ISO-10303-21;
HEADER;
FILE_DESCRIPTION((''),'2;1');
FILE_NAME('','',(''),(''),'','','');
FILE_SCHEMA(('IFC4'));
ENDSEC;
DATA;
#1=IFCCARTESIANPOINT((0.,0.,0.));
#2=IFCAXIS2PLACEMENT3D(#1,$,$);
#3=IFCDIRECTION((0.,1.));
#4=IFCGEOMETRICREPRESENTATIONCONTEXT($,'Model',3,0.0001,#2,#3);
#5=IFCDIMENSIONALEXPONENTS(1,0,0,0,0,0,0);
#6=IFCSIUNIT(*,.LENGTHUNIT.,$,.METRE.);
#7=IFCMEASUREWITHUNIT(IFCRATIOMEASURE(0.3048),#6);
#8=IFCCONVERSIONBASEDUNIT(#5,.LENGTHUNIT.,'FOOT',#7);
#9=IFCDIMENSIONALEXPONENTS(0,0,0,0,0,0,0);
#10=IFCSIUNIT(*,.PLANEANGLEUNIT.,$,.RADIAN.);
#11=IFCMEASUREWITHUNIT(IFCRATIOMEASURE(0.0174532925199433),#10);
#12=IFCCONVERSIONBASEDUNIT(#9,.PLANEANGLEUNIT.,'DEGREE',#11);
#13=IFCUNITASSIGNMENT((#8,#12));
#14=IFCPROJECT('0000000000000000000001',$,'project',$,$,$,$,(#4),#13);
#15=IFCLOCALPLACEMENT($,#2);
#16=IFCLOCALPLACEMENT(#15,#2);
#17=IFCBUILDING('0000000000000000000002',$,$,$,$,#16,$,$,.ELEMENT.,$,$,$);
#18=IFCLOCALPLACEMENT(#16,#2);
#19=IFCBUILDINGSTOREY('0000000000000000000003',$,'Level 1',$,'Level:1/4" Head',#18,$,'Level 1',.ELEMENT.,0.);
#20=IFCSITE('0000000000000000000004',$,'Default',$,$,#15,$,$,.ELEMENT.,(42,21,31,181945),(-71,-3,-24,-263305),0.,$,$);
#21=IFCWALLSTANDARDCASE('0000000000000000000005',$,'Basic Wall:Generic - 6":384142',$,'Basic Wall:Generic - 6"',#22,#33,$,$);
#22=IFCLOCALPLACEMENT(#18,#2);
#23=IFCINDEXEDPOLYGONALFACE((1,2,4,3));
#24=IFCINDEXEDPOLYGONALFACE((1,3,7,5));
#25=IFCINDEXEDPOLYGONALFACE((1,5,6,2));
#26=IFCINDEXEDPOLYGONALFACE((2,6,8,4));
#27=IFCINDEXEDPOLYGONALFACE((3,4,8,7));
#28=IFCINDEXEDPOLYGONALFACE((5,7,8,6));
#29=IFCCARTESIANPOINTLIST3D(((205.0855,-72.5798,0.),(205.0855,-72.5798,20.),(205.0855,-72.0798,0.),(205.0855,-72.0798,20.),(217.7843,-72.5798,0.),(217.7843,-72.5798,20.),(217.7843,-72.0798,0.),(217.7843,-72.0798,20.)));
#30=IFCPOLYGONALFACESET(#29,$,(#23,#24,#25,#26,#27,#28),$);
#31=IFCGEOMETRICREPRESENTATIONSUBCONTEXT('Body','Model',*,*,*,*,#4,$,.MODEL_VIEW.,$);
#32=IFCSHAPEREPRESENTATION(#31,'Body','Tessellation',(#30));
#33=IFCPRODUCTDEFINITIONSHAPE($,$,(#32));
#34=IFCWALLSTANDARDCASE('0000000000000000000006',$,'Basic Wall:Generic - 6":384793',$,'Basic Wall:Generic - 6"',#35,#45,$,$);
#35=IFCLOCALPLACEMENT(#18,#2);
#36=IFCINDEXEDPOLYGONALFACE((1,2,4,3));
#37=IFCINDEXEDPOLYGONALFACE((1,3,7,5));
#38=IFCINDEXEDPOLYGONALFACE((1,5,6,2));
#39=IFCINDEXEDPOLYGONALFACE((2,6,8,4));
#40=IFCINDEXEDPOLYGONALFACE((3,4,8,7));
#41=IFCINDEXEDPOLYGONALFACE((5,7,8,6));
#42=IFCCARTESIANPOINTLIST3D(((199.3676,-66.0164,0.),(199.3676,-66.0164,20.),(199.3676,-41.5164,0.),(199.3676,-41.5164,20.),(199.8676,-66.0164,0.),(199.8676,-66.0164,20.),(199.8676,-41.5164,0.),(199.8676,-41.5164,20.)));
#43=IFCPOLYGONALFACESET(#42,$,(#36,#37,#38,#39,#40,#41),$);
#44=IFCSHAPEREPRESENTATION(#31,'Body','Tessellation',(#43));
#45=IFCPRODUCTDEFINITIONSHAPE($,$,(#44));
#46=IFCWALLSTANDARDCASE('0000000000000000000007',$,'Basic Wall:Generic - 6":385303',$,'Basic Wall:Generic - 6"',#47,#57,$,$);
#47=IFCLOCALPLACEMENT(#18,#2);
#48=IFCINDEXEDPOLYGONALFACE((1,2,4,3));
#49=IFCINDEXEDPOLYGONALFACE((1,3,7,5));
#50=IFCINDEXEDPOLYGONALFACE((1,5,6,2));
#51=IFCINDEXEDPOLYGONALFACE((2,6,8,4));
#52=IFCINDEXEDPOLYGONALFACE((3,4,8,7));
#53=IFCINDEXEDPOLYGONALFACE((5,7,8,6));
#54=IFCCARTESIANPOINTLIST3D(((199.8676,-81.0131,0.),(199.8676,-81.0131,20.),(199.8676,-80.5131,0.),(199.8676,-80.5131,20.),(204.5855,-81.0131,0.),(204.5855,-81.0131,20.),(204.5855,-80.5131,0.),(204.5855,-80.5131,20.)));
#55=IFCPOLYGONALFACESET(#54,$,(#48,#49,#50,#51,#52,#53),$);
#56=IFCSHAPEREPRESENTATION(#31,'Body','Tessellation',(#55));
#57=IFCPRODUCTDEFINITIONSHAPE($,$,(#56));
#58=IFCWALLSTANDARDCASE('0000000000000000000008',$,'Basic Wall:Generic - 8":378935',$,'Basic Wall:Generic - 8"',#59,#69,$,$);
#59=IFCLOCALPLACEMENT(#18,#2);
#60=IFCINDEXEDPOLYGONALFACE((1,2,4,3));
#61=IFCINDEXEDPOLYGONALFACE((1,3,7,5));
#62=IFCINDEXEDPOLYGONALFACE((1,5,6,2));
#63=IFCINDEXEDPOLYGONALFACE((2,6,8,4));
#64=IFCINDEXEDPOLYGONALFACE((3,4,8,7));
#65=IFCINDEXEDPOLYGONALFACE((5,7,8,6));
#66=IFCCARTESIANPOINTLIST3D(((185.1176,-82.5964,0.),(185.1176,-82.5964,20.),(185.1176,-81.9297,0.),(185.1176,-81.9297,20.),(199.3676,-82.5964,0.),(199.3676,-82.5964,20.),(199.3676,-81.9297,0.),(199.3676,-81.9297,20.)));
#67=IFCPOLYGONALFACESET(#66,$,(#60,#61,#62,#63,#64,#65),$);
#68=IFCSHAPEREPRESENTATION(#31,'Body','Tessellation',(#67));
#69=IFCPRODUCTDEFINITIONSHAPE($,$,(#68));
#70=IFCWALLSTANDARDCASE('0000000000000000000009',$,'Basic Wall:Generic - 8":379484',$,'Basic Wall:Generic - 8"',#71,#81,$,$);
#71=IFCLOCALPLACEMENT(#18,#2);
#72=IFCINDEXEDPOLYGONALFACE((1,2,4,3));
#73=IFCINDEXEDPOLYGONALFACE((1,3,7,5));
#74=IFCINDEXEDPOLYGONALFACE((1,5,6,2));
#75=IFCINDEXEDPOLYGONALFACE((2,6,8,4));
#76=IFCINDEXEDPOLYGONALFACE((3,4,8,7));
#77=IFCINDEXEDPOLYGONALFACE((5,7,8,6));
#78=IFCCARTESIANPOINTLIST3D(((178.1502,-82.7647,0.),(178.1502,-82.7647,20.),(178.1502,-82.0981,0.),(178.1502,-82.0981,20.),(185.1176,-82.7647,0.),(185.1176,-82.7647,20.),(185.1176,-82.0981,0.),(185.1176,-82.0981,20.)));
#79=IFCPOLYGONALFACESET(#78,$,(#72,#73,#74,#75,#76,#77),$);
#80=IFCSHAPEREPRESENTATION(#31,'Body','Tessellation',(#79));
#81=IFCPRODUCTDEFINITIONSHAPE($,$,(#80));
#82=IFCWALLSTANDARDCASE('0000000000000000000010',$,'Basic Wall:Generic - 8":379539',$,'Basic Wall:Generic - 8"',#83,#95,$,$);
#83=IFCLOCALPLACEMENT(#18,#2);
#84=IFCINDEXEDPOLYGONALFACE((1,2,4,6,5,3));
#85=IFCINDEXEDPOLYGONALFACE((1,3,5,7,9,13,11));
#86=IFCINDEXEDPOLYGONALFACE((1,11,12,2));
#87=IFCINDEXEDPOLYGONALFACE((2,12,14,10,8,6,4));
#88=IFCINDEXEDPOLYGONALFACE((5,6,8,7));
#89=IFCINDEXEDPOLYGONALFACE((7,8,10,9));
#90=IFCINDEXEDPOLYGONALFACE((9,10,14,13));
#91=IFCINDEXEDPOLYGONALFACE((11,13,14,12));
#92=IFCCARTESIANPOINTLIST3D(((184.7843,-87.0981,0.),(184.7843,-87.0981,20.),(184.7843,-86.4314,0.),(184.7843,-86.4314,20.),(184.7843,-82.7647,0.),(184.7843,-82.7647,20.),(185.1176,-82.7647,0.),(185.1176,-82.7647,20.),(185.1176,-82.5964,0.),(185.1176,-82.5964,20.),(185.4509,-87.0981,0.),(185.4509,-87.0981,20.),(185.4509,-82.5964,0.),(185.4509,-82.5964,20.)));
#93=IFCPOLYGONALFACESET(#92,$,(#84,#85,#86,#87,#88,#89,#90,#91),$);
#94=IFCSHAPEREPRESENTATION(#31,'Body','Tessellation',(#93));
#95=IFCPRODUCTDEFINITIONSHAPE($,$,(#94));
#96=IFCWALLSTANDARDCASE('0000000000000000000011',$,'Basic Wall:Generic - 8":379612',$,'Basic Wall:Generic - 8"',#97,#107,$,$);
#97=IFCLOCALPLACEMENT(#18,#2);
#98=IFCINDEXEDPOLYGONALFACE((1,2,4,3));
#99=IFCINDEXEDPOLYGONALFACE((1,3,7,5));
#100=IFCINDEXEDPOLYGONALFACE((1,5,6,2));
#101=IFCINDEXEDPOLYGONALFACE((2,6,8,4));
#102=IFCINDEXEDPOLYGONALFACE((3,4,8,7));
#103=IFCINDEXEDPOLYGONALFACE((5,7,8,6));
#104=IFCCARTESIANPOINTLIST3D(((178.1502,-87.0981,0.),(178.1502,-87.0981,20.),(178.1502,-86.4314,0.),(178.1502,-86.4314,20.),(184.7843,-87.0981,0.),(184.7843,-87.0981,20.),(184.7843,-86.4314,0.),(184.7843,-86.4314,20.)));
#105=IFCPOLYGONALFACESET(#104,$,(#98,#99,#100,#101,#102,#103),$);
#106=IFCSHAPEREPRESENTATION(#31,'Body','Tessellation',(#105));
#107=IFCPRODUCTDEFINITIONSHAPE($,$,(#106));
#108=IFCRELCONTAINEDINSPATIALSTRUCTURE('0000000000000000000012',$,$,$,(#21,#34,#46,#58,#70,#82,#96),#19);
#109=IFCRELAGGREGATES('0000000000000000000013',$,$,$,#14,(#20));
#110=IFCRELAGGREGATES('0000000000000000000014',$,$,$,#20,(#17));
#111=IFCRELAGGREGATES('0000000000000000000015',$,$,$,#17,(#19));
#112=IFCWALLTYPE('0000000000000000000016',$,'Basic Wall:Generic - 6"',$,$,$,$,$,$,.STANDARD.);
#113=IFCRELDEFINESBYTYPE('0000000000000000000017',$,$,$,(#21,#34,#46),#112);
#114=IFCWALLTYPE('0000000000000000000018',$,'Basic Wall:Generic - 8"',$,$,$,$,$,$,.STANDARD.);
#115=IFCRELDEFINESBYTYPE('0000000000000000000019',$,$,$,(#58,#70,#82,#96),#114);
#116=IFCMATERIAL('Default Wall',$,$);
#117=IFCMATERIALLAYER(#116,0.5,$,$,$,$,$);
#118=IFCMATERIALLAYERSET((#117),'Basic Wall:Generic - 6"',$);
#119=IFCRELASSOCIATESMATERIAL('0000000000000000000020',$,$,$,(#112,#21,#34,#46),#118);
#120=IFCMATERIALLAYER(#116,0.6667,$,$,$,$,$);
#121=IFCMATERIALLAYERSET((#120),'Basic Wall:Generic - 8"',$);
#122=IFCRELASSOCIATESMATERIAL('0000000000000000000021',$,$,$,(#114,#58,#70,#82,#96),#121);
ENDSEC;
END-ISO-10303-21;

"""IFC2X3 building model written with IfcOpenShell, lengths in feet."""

from ifc_helpers import new_model, entity, si_unit, converted_unit, direction, frame, frame_2d, origin, place, context, subcontext, project, spatial, polyline, rectangle, outline, extrude, material, layer, layer_set, layer_usage, type_object, element, save


model = new_model("IFC2X3")

# Units and contexts
model_context = context("Model", 3, precision=0.0001, world=origin(), true_north=direction((0.0, 1.0)))
body_context = subcontext(model_context, "Body", "Model", "MODEL_VIEW")
ifc_project = project(units=[converted_unit("LENGTHUNIT", "FOOT", entity("IfcRatioMeasure", 0.3048), si_unit("LENGTHUNIT", "METRE"), dimensions=[1, 0, 0, 0, 0, 0, 0]), converted_unit("PLANEANGLEUNIT", "DEGREE", entity("IfcRatioMeasure", 0.0174532925199433), si_unit("PLANEANGLEUNIT", "RADIAN"), dimensions=[0, 0, 0, 0, 0, 0, 0])], contexts=[model_context])

# Site, building, storey
site_placement = place(None, origin())
site = spatial("IfcSite", under=ifc_project, at=site_placement, Name="Default", CompositionType="ELEMENT", RefLatitude=(42, 21, 31, 181945), RefLongitude=(-71, -3, -24, -263305), RefElevation=0.0)
building_placement = place(site_placement, origin())
building = spatial("IfcBuilding", under=site, at=building_placement, CompositionType="ELEMENT")
storey_placement = place(building_placement, origin())
storey = spatial("IfcBuildingStorey", under=building, at=storey_placement, Name="Level 1", ObjectType="Level:1/4\" Head", LongName="Level 1", CompositionType="ELEMENT", Elevation=0.0)

# Walls
ifc_material = material(Name="Default Wall")
ifc_layer_1 = layer(ifc_material, 0.5)
ifc_layer_set_1 = layer_set([ifc_layer_1], Name="Basic Wall:Generic - 6\"")
wall_type_1 = type_object("IfcWallType", Name="Basic Wall:Generic - 6\"", PredefinedType="STANDARD", material=ifc_layer_set_1)
ifc_layer_usage_1 = layer_usage(ifc_layer_set_1, "AXIS2", "NEGATIVE", 0.25)
wall_1_placement = place(storey_placement, frame((205.0855, -72.3298, 0.0)))
element("IfcWallStandardCase", 1, at=wall_1_placement, inside=storey, type_object=wall_type_1, material=ifc_layer_usage_1, Name="Basic Wall:Generic - 6\":384142", ObjectType="Basic Wall:Generic - 6\"", context=body_context, shape_type="SweptSolid", body=[
    extrude(rectangle(XDim=12.6987, YDim=0.5, at=frame_2d((6.3494, 0.0), x_axis=(-1.0, 0.0))), origin(), (0.0, 0.0, 1.0), 20.0),
])
ifc_layer_usage_2 = layer_usage(ifc_layer_set_1, "AXIS2", "NEGATIVE", 0.25)
wall_2_placement = place(storey_placement, frame((199.6176, -66.0164, 0.0), z_axis=(0.0, 0.0, 1.0), x_axis=(0.0, 1.0, 0.0)))
element("IfcWallStandardCase", 2, at=wall_2_placement, inside=storey, type_object=wall_type_1, material=ifc_layer_usage_2, Name="Basic Wall:Generic - 6\":384793", ObjectType="Basic Wall:Generic - 6\"", context=body_context, shape_type="SweptSolid", body=[
    extrude(rectangle(XDim=24.5, YDim=0.5, at=frame_2d((12.25, 0.0), x_axis=(-1.0, 0.0))), origin(), (0.0, 0.0, 1.0), 20.0),
])
ifc_layer_usage_3 = layer_usage(ifc_layer_set_1, "AXIS2", "NEGATIVE", 0.25)
wall_3_placement = place(storey_placement, frame((204.5855, -80.7631, 0.0), z_axis=(0.0, 0.0, 1.0), x_axis=(-1.0, 0.0, 0.0)))
element("IfcWallStandardCase", 3, at=wall_3_placement, inside=storey, type_object=wall_type_1, material=ifc_layer_usage_3, Name="Basic Wall:Generic - 6\":385303", ObjectType="Basic Wall:Generic - 6\"", context=body_context, shape_type="SweptSolid", body=[
    extrude(rectangle(XDim=4.7179, YDim=0.5, at=frame_2d((2.359, 0.0), x_axis=(-1.0, 0.0))), origin(), (0.0, 0.0, 1.0), 20.0),
])
ifc_layer_2 = layer(ifc_material, 0.6667)
ifc_layer_set_2 = layer_set([ifc_layer_2], Name="Basic Wall:Generic - 8\"")
ifc_layer_usage_4 = layer_usage(ifc_layer_set_2, "AXIS2", "NEGATIVE", 0.3333)
wall_type_2 = type_object("IfcWallType", Name="Basic Wall:Generic - 8\"", PredefinedType="STANDARD", material=ifc_layer_set_2)
wall_4_placement = place(storey_placement, frame((199.3676, -82.2631, 0.0), z_axis=(0.0, 0.0, 1.0), x_axis=(-1.0, 0.0, 0.0)))
element("IfcWallStandardCase", 4, at=wall_4_placement, inside=storey, type_object=wall_type_2, material=ifc_layer_usage_4, Name="Basic Wall:Generic - 8\":378935", ObjectType="Basic Wall:Generic - 8\"", context=body_context, shape_type="SweptSolid", body=[
    extrude(rectangle(XDim=14.25, YDim=0.6667, at=frame_2d((7.125, 0.0), x_axis=(-1.0, 0.0))), origin(), (0.0, 0.0, 1.0), 20.0),
])
ifc_layer_usage_5 = layer_usage(ifc_layer_set_2, "AXIS2", "NEGATIVE", 0.3333)
wall_5_placement = place(storey_placement, frame((178.1502, -82.4314, 0.0)))
element("IfcWallStandardCase", 5, at=wall_5_placement, inside=storey, type_object=wall_type_2, material=ifc_layer_usage_5, Name="Basic Wall:Generic - 8\":379484", ObjectType="Basic Wall:Generic - 8\"", context=body_context, shape_type="SweptSolid", body=[
    extrude(rectangle(XDim=6.9674, YDim=0.6667, at=frame_2d((3.4837, 0.0), x_axis=(-1.0, 0.0))), origin(), (0.0, 0.0, 1.0), 20.0),
])
ifc_layer_usage_6 = layer_usage(ifc_layer_set_2, "AXIS2", "NEGATIVE", 0.3333)
wall_6_placement = place(storey_placement, frame((185.1176, -82.5964, 0.0), z_axis=(0.0, 0.0, 1.0), x_axis=(0.0, -1.0, 0.0)))
element("IfcWallStandardCase", 6, at=wall_6_placement, inside=storey, type_object=wall_type_2, material=ifc_layer_usage_6, Name="Basic Wall:Generic - 8\":379539", ObjectType="Basic Wall:Generic - 8\"", context=body_context, shape_type="SweptSolid", body=[
    extrude(outline(polyline([(4.5017, -0.3333), (4.5017, 0.3333), (0.0, 0.3333), (0.0, 0.0), (0.1683, 0.0), (0.1683, -0.3333), (3.835, -0.3333), (4.5017, -0.3333)])), origin(), (0.0, 0.0, 1.0), 20.0),
])
ifc_layer_usage_7 = layer_usage(ifc_layer_set_2, "AXIS2", "NEGATIVE", 0.3333)
wall_7_placement = place(storey_placement, frame((184.7843, -86.7647, 0.0), z_axis=(0.0, 0.0, 1.0), x_axis=(-1.0, 0.0, 0.0)))
element("IfcWallStandardCase", 7, at=wall_7_placement, inside=storey, type_object=wall_type_2, material=ifc_layer_usage_7, Name="Basic Wall:Generic - 8\":379612", ObjectType="Basic Wall:Generic - 8\"", context=body_context, shape_type="SweptSolid", body=[
    extrude(rectangle(XDim=6.6341, YDim=0.6667, at=frame_2d((3.3171, 0.0), x_axis=(-1.0, 0.0))), origin(), (0.0, 0.0, 1.0), 20.0),
])

save(model, "model.ifc")
